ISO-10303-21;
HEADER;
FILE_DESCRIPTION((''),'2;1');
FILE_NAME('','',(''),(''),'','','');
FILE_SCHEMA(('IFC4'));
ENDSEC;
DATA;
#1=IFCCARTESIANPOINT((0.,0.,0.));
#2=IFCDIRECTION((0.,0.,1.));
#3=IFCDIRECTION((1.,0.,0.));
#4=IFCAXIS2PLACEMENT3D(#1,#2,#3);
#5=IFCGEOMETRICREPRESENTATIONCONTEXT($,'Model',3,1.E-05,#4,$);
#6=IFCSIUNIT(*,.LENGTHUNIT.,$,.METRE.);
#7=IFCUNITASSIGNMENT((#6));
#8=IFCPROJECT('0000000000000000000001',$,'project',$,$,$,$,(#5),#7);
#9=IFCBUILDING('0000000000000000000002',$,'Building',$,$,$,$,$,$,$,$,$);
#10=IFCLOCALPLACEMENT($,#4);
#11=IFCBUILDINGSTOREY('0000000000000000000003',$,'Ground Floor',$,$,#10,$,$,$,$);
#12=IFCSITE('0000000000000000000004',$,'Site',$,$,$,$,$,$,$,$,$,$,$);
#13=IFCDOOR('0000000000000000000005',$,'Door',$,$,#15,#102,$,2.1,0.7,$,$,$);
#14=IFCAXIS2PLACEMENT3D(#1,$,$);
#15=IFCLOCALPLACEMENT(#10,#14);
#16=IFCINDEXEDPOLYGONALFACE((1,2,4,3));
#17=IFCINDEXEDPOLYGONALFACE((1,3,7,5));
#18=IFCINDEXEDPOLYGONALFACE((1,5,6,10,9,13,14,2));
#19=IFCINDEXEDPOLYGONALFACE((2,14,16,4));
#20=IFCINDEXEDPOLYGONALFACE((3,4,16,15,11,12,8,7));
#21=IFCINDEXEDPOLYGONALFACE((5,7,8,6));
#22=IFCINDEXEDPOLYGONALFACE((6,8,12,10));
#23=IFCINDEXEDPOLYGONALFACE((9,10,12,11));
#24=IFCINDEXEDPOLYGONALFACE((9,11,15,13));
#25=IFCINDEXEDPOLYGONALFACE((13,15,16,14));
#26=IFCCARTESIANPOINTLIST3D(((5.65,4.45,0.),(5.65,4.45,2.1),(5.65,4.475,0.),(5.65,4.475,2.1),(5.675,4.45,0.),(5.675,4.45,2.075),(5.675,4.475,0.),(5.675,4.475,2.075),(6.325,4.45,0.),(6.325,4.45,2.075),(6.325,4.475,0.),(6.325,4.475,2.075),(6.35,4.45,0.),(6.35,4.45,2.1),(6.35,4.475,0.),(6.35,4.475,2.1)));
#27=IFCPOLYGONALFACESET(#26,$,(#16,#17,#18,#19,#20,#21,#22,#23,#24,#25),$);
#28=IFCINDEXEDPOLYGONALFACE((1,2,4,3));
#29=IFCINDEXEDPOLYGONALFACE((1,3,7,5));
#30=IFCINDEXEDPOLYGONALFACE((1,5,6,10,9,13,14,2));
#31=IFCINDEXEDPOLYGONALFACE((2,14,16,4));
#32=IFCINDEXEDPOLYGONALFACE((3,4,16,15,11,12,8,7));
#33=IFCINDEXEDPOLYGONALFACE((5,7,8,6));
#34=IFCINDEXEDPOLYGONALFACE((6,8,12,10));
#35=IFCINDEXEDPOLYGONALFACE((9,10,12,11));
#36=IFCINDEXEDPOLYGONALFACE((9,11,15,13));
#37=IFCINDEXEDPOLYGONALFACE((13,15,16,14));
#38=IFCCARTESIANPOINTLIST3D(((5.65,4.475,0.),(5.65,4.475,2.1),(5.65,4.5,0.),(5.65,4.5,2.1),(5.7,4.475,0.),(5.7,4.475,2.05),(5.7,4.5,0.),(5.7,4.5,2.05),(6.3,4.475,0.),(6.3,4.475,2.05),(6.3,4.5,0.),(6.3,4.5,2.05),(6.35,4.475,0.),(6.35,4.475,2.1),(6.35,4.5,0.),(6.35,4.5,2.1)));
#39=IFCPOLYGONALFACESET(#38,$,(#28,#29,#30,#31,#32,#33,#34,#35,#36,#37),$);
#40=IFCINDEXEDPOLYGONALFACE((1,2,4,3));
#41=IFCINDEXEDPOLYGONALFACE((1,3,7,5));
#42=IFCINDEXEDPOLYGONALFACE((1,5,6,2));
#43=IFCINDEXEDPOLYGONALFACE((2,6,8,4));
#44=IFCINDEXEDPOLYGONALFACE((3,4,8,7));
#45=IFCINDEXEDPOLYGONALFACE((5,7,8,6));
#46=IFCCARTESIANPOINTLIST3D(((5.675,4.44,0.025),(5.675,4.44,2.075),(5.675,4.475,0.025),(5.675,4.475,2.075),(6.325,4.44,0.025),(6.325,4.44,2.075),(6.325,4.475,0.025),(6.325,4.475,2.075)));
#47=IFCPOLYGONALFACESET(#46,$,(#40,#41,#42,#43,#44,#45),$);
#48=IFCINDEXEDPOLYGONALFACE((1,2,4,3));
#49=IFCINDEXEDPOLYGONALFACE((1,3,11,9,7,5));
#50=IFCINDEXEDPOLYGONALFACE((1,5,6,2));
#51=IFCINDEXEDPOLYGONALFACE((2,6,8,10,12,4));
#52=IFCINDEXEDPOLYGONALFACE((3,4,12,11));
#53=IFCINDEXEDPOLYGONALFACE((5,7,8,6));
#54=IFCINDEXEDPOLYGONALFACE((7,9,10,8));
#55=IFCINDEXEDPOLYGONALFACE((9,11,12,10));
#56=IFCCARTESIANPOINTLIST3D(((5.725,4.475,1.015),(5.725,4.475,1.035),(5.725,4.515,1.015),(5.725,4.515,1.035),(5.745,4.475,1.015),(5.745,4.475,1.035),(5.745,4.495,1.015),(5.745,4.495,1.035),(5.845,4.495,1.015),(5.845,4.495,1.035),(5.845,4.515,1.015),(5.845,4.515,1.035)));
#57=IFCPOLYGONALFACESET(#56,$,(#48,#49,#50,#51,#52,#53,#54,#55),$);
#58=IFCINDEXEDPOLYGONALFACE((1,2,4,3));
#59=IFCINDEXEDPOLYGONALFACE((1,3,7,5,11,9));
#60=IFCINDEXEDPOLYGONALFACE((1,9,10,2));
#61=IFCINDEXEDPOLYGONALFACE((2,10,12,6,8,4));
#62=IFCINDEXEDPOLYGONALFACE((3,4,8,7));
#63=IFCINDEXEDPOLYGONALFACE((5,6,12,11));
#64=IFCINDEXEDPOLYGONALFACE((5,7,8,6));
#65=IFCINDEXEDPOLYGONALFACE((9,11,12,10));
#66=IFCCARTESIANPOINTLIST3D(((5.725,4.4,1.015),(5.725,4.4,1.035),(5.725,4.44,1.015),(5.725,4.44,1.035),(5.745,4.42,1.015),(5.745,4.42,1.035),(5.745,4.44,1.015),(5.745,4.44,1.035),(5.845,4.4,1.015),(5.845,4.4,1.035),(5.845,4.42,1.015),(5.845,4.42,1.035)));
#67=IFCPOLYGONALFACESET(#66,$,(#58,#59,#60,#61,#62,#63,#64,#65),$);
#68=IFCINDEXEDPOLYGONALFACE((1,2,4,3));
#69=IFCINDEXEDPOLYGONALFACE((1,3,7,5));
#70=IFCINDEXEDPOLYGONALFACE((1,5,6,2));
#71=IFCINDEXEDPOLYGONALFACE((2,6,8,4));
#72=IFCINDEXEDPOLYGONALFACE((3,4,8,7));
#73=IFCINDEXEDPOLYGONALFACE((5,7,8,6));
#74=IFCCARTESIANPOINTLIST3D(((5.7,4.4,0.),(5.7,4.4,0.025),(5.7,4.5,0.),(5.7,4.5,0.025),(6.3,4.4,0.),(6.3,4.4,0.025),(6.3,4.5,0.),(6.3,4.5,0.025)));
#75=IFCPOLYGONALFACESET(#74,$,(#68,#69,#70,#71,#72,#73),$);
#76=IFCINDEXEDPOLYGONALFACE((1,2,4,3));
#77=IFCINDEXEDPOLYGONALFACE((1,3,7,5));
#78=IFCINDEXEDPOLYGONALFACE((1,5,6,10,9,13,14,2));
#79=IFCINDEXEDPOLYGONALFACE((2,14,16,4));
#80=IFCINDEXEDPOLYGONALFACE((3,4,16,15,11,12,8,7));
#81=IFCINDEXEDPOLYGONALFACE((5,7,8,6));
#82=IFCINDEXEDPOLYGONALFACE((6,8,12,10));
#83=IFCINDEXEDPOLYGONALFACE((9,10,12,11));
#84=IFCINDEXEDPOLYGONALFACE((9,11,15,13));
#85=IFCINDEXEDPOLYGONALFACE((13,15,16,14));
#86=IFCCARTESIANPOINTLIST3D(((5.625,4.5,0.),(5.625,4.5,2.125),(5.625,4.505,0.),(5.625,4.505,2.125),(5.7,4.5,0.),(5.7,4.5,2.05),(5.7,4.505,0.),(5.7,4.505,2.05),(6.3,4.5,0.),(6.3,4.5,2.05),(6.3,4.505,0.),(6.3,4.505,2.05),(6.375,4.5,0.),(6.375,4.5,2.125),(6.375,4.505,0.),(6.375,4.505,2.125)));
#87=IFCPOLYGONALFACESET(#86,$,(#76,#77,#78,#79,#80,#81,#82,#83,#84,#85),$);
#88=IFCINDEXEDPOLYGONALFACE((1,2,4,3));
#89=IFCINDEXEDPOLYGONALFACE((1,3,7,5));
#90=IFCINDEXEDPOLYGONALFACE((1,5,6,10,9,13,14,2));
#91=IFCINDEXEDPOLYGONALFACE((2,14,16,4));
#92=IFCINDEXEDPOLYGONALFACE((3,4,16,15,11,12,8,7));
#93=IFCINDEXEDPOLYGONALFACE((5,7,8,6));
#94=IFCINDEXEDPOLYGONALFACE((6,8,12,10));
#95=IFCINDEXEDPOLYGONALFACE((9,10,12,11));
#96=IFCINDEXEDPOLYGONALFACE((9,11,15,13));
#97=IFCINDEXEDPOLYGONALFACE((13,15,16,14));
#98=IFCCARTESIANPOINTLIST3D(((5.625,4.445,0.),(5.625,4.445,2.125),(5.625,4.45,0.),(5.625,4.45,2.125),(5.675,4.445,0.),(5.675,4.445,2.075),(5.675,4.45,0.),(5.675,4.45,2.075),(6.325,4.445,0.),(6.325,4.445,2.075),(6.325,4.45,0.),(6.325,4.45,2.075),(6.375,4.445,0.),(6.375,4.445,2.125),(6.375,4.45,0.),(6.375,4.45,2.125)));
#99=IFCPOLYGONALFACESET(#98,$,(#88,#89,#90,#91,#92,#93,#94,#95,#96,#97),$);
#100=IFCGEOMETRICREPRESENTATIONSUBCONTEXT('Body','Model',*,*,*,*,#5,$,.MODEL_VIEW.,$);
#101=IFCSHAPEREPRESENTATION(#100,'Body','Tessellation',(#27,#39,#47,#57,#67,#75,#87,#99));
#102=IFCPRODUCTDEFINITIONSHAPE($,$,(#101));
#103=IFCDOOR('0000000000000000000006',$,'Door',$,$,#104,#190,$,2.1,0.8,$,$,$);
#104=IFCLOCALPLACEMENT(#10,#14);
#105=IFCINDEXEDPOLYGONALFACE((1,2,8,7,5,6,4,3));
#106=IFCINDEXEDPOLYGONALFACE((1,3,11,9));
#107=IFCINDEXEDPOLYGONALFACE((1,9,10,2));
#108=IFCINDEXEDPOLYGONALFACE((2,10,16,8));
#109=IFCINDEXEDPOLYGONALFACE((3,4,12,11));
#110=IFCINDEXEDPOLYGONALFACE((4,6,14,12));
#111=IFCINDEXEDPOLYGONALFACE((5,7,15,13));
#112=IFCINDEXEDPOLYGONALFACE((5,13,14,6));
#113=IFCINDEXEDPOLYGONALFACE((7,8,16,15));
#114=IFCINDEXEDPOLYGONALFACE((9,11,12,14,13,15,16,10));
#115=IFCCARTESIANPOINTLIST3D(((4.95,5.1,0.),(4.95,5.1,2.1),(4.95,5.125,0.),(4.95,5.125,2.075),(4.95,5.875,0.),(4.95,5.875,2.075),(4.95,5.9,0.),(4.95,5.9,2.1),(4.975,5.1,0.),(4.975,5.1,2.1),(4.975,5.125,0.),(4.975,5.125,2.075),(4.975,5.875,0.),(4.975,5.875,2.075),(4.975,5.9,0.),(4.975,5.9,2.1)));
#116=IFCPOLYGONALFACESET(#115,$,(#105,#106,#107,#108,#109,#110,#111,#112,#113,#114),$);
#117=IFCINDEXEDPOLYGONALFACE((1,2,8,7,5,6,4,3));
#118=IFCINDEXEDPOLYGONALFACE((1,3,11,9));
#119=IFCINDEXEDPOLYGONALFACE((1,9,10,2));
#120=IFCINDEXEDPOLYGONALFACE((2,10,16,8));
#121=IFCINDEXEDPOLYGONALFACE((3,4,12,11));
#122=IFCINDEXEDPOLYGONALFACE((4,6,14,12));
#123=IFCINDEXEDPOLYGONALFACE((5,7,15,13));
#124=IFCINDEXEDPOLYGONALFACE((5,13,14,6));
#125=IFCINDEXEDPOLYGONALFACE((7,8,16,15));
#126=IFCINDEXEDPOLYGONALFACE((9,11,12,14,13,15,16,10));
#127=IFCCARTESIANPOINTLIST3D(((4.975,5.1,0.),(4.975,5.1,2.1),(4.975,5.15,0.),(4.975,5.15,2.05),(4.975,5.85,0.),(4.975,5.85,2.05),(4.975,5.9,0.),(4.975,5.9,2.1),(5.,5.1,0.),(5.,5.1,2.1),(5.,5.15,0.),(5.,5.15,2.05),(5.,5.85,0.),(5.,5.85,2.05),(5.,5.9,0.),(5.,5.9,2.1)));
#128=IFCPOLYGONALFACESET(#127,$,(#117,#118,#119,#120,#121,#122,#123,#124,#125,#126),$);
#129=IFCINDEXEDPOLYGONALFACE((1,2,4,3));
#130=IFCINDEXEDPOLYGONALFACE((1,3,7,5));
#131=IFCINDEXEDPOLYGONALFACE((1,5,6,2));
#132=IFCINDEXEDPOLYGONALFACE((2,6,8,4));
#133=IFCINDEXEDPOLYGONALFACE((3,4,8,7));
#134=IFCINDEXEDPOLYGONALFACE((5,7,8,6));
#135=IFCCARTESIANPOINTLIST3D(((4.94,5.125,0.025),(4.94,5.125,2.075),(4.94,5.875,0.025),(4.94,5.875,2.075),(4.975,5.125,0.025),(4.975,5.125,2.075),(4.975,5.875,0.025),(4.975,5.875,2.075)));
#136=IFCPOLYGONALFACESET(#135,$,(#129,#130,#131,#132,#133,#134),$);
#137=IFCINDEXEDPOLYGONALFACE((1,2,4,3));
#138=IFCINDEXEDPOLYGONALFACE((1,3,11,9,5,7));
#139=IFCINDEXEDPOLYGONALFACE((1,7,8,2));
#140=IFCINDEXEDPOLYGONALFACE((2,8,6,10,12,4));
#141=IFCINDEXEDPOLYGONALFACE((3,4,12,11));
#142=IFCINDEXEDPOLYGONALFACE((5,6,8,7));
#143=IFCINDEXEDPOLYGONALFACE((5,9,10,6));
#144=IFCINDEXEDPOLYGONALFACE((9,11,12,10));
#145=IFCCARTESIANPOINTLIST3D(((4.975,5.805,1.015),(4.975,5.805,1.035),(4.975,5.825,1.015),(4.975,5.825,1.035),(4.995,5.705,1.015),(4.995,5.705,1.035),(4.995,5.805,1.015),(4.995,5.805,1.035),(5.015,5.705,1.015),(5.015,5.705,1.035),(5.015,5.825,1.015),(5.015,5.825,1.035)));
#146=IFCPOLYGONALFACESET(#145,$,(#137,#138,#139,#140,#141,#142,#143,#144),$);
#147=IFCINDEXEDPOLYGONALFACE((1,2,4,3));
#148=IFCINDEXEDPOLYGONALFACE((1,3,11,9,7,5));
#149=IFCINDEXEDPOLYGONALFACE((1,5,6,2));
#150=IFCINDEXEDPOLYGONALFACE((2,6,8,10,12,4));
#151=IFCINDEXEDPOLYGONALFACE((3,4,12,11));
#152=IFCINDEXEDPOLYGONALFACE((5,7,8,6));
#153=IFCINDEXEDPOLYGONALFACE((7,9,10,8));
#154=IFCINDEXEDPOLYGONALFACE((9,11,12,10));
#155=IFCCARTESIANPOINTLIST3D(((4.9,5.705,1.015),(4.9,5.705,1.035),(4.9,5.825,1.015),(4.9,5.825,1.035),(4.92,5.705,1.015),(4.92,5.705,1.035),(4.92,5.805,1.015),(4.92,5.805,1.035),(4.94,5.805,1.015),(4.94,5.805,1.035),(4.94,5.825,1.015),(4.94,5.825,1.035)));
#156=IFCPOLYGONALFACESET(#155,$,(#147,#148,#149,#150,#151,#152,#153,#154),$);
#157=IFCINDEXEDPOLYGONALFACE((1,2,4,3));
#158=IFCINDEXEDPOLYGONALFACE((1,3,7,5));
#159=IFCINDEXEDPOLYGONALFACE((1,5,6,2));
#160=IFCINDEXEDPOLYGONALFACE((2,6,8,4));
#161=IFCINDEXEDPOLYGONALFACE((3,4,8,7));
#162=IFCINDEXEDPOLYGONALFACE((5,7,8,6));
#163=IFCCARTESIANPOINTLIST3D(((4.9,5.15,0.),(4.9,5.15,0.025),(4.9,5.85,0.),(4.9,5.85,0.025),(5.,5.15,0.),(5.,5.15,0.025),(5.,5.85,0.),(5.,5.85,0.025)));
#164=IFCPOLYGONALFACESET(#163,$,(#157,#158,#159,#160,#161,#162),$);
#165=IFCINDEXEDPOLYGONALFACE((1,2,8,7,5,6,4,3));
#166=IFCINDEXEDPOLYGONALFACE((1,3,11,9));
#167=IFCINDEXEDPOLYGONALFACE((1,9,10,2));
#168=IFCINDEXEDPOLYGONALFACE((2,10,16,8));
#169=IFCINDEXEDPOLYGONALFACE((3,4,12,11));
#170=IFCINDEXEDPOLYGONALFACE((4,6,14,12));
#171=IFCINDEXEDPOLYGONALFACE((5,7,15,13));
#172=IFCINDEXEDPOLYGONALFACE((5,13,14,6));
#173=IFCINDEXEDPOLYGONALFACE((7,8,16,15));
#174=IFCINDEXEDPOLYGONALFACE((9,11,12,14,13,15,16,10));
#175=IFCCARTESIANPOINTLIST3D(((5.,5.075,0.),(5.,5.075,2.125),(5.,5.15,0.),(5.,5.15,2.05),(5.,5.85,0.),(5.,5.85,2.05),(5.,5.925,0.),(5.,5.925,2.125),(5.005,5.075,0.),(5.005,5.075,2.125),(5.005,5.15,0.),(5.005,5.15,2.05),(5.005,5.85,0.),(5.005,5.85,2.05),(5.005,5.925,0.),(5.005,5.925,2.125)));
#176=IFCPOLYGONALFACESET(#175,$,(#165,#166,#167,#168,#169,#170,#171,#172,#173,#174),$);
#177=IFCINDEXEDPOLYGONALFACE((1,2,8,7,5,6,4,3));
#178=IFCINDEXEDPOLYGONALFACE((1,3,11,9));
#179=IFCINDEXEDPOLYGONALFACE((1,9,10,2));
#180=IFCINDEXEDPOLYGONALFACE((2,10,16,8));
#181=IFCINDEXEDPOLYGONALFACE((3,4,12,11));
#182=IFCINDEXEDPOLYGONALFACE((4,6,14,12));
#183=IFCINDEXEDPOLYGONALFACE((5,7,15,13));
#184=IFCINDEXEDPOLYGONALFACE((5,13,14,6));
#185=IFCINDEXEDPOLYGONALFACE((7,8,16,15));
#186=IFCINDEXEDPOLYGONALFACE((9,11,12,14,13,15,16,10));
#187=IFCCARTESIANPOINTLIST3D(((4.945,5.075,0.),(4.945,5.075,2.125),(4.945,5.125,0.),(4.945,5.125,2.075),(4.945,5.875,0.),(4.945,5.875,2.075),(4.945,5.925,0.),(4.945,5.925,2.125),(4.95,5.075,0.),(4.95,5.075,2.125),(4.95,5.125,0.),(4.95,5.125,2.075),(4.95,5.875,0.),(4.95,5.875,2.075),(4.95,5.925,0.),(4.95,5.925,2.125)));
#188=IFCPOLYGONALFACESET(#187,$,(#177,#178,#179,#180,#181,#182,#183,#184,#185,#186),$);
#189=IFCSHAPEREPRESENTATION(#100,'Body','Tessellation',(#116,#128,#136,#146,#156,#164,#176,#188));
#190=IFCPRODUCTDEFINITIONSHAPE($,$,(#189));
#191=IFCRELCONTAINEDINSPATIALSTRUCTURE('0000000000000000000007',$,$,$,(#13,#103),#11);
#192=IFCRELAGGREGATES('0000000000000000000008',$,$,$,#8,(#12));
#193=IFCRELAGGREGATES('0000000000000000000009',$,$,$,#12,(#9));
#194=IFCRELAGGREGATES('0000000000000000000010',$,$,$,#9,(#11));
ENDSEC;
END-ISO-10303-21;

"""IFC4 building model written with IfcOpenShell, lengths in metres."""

from ifc_helpers import new_model, si_unit, frame, origin_with_axes, place, context, subcontext, project, spatial, line, indexed_curve, outline, extrude, element, save


model = new_model("IFC4")

# Units and contexts
model_context = context("Model", 3, precision=1e-05, world=origin_with_axes())
body_context = subcontext(model_context, "Body", "Model", "MODEL_VIEW")
ifc_project = project(units=[si_unit("LENGTHUNIT", "METRE")], contexts=[model_context])

# Site, building, storey
site = spatial("IfcSite", under=ifc_project, Name="Site")
building = spatial("IfcBuilding", under=site, Name="Building")
storey_placement = place(None, origin_with_axes())
storey = spatial("IfcBuildingStorey", under=building, at=storey_placement, Name="Ground Floor")

# Doors
door_1_placement = place(storey_placement, frame((6.35, 4.5, 0.0), z_axis=(0.0, 0.0, 1.0), x_axis=(-1.0, 0.0, 0.0)))
element("IfcDoor", 1, at=door_1_placement, inside=storey, Name="Door", OverallHeight=2.1, OverallWidth=0.7, context=body_context, shape_type="SweptSolid", body=[
    extrude(outline(indexed_curve([(0.0, 0.0), (0.0, 2.1), (0.7, 2.1), (0.7, 0.0), (0.675, 0.0), (0.675, 2.075), (0.025, 2.075), (0.025, 0.0)], segments=[line(1, 2, 3, 4, 5, 6, 7, 8, 1)])), frame((0.0, 0.025, 0.0), z_axis=(0.0, -1.0, 0.0), x_axis=(1.0, 0.0, 0.0)), (0.0, 0.0, -1.0), 0.025),
    extrude(outline(indexed_curve([(0.0, 0.0), (0.0, 2.1), (0.7, 2.1), (0.7, 0.0), (0.65, 0.0), (0.65, 2.05), (0.05, 2.05), (0.05, 0.0)], segments=[line(1, 2, 3, 4, 5, 6, 7, 8, 1)])), frame((0.0, 0.0, 0.0), z_axis=(0.0, -1.0, 0.0), x_axis=(1.0, 0.0, 0.0)), (0.0, 0.0, -1.0), 0.025),
    extrude(outline(indexed_curve([(0.0, 0.0), (0.65, 0.0), (0.65, 0.035), (0.0, 0.035)], segments=[line(1, 2, 3, 4, 1)])), frame((0.025, 0.025, 0.025), z_axis=(0.0, 0.0, 1.0), x_axis=(1.0, 0.0, 0.0)), (0.0, 0.0, 1.0), 2.05),
    extrude(outline(indexed_curve([(0.0, 0.0), (0.0, -0.04), (-0.12, -0.04), (-0.12, -0.02), (-0.02, -0.02), (-0.02, 0.0)], segments=[line(1, 2, 3, 4, 5, 6, 1)])), frame((0.625, 0.025, 1.015), z_axis=(0.0, 0.0, 1.0), x_axis=(1.0, 0.0, 0.0)), (0.0, 0.0, 1.0), 0.02),
    extrude(outline(indexed_curve([(0.0, 0.0), (0.0, 0.04), (-0.12, 0.04), (-0.12, 0.02), (-0.02, 0.02), (-0.02, 0.0)], segments=[line(1, 2, 3, 4, 5, 6, 1)])), frame((0.625, 0.06, 1.015), z_axis=(0.0, 0.0, 1.0), x_axis=(1.0, 0.0, 0.0)), (0.0, 0.0, 1.0), 0.02),
    extrude(outline(indexed_curve([(0.0, 0.0), (0.6, 0.0), (0.6, 0.1), (0.0, 0.1)], segments=[line(1, 2, 3, 4, 1)])), frame((0.05, 0.0, 0.0), z_axis=(0.0, 0.0, 1.0), x_axis=(1.0, 0.0, 0.0)), (0.0, 0.0, 1.0), 0.025),
    extrude(outline(indexed_curve([(0.0, 0.0), (0.0, 2.125), (0.75, 2.125), (0.75, 0.0), (0.675, 0.0), (0.675, 2.05), (0.075, 2.05), (0.075, 0.0)], segments=[line(1, 2, 3, 4, 5, 6, 7, 8, 1)])), frame((-0.025, -0.005, 0.0), z_axis=(0.0, -1.0, 0.0), x_axis=(1.0, 0.0, 0.0)), (0.0, 0.0, -1.0), 0.005),
    extrude(outline(indexed_curve([(0.0, 0.0), (0.0, 2.125), (0.75, 2.125), (0.75, 0.0), (0.7, 0.0), (0.7, 2.075), (0.05, 2.075), (0.05, 0.0)], segments=[line(1, 2, 3, 4, 5, 6, 7, 8, 1)])), frame((-0.025, 0.05, 0.0), z_axis=(0.0, -1.0, 0.0), x_axis=(1.0, 0.0, 0.0)), (0.0, 0.0, -1.0), 0.005),
])
door_2_placement = place(storey_placement, frame((5.0, 5.1, 0.0), z_axis=(0.0, 0.0, 1.0), x_axis=(0.0, 1.0, 0.0)))
element("IfcDoor", 2, at=door_2_placement, inside=storey, Name="Door", OverallHeight=2.1, OverallWidth=0.8, context=body_context, shape_type="SweptSolid", body=[
    extrude(outline(indexed_curve([(0.0, 0.0), (0.0, 2.1), (0.8, 2.1), (0.8, 0.0), (0.775, 0.0), (0.775, 2.075), (0.025, 2.075), (0.025, 0.0)], segments=[line(1, 2, 3, 4, 5, 6, 7, 8, 1)])), frame((0.0, 0.025, 0.0), z_axis=(0.0, -1.0, 0.0), x_axis=(1.0, 0.0, 0.0)), (0.0, 0.0, -1.0), 0.025),
    extrude(outline(indexed_curve([(0.0, 0.0), (0.0, 2.1), (0.8, 2.1), (0.8, 0.0), (0.75, 0.0), (0.75, 2.05), (0.05, 2.05), (0.05, 0.0)], segments=[line(1, 2, 3, 4, 5, 6, 7, 8, 1)])), frame((0.0, 0.0, 0.0), z_axis=(0.0, -1.0, 0.0), x_axis=(1.0, 0.0, 0.0)), (0.0, 0.0, -1.0), 0.025),
    extrude(outline(indexed_curve([(0.0, 0.0), (0.75, 0.0), (0.75, 0.035), (0.0, 0.035)], segments=[line(1, 2, 3, 4, 1)])), frame((0.025, 0.025, 0.025), z_axis=(0.0, 0.0, 1.0), x_axis=(1.0, 0.0, 0.0)), (0.0, 0.0, 1.0), 2.05),
    extrude(outline(indexed_curve([(0.0, 0.0), (0.0, -0.04), (-0.12, -0.04), (-0.12, -0.02), (-0.02, -0.02), (-0.02, 0.0)], segments=[line(1, 2, 3, 4, 5, 6, 1)])), frame((0.725, 0.025, 1.015), z_axis=(0.0, 0.0, 1.0), x_axis=(1.0, 0.0, 0.0)), (0.0, 0.0, 1.0), 0.02),
    extrude(outline(indexed_curve([(0.0, 0.0), (0.0, 0.04), (-0.12, 0.04), (-0.12, 0.02), (-0.02, 0.02), (-0.02, 0.0)], segments=[line(1, 2, 3, 4, 5, 6, 1)])), frame((0.725, 0.06, 1.015), z_axis=(0.0, 0.0, 1.0), x_axis=(1.0, 0.0, 0.0)), (0.0, 0.0, 1.0), 0.02),
    extrude(outline(indexed_curve([(0.0, 0.0), (0.7, 0.0), (0.7, 0.1), (0.0, 0.1)], segments=[line(1, 2, 3, 4, 1)])), frame((0.05, 0.0, 0.0), z_axis=(0.0, 0.0, 1.0), x_axis=(1.0, 0.0, 0.0)), (0.0, 0.0, 1.0), 0.025),
    extrude(outline(indexed_curve([(0.0, 0.0), (0.0, 2.125), (0.85, 2.125), (0.85, 0.0), (0.775, 0.0), (0.775, 2.05), (0.075, 2.05), (0.075, 0.0)], segments=[line(1, 2, 3, 4, 5, 6, 7, 8, 1)])), frame((-0.025, -0.005, 0.0), z_axis=(0.0, -1.0, 0.0), x_axis=(1.0, 0.0, 0.0)), (0.0, 0.0, -1.0), 0.005),
    extrude(outline(indexed_curve([(0.0, 0.0), (0.0, 2.125), (0.85, 2.125), (0.85, 0.0), (0.8, 0.0), (0.8, 2.075), (0.05, 2.075), (0.05, 0.0)], segments=[line(1, 2, 3, 4, 5, 6, 7, 8, 1)])), frame((-0.025, 0.05, 0.0), z_axis=(0.0, -1.0, 0.0), x_axis=(1.0, 0.0, 0.0)), (0.0, 0.0, -1.0), 0.005),
])

save(model, "model.ifc")
